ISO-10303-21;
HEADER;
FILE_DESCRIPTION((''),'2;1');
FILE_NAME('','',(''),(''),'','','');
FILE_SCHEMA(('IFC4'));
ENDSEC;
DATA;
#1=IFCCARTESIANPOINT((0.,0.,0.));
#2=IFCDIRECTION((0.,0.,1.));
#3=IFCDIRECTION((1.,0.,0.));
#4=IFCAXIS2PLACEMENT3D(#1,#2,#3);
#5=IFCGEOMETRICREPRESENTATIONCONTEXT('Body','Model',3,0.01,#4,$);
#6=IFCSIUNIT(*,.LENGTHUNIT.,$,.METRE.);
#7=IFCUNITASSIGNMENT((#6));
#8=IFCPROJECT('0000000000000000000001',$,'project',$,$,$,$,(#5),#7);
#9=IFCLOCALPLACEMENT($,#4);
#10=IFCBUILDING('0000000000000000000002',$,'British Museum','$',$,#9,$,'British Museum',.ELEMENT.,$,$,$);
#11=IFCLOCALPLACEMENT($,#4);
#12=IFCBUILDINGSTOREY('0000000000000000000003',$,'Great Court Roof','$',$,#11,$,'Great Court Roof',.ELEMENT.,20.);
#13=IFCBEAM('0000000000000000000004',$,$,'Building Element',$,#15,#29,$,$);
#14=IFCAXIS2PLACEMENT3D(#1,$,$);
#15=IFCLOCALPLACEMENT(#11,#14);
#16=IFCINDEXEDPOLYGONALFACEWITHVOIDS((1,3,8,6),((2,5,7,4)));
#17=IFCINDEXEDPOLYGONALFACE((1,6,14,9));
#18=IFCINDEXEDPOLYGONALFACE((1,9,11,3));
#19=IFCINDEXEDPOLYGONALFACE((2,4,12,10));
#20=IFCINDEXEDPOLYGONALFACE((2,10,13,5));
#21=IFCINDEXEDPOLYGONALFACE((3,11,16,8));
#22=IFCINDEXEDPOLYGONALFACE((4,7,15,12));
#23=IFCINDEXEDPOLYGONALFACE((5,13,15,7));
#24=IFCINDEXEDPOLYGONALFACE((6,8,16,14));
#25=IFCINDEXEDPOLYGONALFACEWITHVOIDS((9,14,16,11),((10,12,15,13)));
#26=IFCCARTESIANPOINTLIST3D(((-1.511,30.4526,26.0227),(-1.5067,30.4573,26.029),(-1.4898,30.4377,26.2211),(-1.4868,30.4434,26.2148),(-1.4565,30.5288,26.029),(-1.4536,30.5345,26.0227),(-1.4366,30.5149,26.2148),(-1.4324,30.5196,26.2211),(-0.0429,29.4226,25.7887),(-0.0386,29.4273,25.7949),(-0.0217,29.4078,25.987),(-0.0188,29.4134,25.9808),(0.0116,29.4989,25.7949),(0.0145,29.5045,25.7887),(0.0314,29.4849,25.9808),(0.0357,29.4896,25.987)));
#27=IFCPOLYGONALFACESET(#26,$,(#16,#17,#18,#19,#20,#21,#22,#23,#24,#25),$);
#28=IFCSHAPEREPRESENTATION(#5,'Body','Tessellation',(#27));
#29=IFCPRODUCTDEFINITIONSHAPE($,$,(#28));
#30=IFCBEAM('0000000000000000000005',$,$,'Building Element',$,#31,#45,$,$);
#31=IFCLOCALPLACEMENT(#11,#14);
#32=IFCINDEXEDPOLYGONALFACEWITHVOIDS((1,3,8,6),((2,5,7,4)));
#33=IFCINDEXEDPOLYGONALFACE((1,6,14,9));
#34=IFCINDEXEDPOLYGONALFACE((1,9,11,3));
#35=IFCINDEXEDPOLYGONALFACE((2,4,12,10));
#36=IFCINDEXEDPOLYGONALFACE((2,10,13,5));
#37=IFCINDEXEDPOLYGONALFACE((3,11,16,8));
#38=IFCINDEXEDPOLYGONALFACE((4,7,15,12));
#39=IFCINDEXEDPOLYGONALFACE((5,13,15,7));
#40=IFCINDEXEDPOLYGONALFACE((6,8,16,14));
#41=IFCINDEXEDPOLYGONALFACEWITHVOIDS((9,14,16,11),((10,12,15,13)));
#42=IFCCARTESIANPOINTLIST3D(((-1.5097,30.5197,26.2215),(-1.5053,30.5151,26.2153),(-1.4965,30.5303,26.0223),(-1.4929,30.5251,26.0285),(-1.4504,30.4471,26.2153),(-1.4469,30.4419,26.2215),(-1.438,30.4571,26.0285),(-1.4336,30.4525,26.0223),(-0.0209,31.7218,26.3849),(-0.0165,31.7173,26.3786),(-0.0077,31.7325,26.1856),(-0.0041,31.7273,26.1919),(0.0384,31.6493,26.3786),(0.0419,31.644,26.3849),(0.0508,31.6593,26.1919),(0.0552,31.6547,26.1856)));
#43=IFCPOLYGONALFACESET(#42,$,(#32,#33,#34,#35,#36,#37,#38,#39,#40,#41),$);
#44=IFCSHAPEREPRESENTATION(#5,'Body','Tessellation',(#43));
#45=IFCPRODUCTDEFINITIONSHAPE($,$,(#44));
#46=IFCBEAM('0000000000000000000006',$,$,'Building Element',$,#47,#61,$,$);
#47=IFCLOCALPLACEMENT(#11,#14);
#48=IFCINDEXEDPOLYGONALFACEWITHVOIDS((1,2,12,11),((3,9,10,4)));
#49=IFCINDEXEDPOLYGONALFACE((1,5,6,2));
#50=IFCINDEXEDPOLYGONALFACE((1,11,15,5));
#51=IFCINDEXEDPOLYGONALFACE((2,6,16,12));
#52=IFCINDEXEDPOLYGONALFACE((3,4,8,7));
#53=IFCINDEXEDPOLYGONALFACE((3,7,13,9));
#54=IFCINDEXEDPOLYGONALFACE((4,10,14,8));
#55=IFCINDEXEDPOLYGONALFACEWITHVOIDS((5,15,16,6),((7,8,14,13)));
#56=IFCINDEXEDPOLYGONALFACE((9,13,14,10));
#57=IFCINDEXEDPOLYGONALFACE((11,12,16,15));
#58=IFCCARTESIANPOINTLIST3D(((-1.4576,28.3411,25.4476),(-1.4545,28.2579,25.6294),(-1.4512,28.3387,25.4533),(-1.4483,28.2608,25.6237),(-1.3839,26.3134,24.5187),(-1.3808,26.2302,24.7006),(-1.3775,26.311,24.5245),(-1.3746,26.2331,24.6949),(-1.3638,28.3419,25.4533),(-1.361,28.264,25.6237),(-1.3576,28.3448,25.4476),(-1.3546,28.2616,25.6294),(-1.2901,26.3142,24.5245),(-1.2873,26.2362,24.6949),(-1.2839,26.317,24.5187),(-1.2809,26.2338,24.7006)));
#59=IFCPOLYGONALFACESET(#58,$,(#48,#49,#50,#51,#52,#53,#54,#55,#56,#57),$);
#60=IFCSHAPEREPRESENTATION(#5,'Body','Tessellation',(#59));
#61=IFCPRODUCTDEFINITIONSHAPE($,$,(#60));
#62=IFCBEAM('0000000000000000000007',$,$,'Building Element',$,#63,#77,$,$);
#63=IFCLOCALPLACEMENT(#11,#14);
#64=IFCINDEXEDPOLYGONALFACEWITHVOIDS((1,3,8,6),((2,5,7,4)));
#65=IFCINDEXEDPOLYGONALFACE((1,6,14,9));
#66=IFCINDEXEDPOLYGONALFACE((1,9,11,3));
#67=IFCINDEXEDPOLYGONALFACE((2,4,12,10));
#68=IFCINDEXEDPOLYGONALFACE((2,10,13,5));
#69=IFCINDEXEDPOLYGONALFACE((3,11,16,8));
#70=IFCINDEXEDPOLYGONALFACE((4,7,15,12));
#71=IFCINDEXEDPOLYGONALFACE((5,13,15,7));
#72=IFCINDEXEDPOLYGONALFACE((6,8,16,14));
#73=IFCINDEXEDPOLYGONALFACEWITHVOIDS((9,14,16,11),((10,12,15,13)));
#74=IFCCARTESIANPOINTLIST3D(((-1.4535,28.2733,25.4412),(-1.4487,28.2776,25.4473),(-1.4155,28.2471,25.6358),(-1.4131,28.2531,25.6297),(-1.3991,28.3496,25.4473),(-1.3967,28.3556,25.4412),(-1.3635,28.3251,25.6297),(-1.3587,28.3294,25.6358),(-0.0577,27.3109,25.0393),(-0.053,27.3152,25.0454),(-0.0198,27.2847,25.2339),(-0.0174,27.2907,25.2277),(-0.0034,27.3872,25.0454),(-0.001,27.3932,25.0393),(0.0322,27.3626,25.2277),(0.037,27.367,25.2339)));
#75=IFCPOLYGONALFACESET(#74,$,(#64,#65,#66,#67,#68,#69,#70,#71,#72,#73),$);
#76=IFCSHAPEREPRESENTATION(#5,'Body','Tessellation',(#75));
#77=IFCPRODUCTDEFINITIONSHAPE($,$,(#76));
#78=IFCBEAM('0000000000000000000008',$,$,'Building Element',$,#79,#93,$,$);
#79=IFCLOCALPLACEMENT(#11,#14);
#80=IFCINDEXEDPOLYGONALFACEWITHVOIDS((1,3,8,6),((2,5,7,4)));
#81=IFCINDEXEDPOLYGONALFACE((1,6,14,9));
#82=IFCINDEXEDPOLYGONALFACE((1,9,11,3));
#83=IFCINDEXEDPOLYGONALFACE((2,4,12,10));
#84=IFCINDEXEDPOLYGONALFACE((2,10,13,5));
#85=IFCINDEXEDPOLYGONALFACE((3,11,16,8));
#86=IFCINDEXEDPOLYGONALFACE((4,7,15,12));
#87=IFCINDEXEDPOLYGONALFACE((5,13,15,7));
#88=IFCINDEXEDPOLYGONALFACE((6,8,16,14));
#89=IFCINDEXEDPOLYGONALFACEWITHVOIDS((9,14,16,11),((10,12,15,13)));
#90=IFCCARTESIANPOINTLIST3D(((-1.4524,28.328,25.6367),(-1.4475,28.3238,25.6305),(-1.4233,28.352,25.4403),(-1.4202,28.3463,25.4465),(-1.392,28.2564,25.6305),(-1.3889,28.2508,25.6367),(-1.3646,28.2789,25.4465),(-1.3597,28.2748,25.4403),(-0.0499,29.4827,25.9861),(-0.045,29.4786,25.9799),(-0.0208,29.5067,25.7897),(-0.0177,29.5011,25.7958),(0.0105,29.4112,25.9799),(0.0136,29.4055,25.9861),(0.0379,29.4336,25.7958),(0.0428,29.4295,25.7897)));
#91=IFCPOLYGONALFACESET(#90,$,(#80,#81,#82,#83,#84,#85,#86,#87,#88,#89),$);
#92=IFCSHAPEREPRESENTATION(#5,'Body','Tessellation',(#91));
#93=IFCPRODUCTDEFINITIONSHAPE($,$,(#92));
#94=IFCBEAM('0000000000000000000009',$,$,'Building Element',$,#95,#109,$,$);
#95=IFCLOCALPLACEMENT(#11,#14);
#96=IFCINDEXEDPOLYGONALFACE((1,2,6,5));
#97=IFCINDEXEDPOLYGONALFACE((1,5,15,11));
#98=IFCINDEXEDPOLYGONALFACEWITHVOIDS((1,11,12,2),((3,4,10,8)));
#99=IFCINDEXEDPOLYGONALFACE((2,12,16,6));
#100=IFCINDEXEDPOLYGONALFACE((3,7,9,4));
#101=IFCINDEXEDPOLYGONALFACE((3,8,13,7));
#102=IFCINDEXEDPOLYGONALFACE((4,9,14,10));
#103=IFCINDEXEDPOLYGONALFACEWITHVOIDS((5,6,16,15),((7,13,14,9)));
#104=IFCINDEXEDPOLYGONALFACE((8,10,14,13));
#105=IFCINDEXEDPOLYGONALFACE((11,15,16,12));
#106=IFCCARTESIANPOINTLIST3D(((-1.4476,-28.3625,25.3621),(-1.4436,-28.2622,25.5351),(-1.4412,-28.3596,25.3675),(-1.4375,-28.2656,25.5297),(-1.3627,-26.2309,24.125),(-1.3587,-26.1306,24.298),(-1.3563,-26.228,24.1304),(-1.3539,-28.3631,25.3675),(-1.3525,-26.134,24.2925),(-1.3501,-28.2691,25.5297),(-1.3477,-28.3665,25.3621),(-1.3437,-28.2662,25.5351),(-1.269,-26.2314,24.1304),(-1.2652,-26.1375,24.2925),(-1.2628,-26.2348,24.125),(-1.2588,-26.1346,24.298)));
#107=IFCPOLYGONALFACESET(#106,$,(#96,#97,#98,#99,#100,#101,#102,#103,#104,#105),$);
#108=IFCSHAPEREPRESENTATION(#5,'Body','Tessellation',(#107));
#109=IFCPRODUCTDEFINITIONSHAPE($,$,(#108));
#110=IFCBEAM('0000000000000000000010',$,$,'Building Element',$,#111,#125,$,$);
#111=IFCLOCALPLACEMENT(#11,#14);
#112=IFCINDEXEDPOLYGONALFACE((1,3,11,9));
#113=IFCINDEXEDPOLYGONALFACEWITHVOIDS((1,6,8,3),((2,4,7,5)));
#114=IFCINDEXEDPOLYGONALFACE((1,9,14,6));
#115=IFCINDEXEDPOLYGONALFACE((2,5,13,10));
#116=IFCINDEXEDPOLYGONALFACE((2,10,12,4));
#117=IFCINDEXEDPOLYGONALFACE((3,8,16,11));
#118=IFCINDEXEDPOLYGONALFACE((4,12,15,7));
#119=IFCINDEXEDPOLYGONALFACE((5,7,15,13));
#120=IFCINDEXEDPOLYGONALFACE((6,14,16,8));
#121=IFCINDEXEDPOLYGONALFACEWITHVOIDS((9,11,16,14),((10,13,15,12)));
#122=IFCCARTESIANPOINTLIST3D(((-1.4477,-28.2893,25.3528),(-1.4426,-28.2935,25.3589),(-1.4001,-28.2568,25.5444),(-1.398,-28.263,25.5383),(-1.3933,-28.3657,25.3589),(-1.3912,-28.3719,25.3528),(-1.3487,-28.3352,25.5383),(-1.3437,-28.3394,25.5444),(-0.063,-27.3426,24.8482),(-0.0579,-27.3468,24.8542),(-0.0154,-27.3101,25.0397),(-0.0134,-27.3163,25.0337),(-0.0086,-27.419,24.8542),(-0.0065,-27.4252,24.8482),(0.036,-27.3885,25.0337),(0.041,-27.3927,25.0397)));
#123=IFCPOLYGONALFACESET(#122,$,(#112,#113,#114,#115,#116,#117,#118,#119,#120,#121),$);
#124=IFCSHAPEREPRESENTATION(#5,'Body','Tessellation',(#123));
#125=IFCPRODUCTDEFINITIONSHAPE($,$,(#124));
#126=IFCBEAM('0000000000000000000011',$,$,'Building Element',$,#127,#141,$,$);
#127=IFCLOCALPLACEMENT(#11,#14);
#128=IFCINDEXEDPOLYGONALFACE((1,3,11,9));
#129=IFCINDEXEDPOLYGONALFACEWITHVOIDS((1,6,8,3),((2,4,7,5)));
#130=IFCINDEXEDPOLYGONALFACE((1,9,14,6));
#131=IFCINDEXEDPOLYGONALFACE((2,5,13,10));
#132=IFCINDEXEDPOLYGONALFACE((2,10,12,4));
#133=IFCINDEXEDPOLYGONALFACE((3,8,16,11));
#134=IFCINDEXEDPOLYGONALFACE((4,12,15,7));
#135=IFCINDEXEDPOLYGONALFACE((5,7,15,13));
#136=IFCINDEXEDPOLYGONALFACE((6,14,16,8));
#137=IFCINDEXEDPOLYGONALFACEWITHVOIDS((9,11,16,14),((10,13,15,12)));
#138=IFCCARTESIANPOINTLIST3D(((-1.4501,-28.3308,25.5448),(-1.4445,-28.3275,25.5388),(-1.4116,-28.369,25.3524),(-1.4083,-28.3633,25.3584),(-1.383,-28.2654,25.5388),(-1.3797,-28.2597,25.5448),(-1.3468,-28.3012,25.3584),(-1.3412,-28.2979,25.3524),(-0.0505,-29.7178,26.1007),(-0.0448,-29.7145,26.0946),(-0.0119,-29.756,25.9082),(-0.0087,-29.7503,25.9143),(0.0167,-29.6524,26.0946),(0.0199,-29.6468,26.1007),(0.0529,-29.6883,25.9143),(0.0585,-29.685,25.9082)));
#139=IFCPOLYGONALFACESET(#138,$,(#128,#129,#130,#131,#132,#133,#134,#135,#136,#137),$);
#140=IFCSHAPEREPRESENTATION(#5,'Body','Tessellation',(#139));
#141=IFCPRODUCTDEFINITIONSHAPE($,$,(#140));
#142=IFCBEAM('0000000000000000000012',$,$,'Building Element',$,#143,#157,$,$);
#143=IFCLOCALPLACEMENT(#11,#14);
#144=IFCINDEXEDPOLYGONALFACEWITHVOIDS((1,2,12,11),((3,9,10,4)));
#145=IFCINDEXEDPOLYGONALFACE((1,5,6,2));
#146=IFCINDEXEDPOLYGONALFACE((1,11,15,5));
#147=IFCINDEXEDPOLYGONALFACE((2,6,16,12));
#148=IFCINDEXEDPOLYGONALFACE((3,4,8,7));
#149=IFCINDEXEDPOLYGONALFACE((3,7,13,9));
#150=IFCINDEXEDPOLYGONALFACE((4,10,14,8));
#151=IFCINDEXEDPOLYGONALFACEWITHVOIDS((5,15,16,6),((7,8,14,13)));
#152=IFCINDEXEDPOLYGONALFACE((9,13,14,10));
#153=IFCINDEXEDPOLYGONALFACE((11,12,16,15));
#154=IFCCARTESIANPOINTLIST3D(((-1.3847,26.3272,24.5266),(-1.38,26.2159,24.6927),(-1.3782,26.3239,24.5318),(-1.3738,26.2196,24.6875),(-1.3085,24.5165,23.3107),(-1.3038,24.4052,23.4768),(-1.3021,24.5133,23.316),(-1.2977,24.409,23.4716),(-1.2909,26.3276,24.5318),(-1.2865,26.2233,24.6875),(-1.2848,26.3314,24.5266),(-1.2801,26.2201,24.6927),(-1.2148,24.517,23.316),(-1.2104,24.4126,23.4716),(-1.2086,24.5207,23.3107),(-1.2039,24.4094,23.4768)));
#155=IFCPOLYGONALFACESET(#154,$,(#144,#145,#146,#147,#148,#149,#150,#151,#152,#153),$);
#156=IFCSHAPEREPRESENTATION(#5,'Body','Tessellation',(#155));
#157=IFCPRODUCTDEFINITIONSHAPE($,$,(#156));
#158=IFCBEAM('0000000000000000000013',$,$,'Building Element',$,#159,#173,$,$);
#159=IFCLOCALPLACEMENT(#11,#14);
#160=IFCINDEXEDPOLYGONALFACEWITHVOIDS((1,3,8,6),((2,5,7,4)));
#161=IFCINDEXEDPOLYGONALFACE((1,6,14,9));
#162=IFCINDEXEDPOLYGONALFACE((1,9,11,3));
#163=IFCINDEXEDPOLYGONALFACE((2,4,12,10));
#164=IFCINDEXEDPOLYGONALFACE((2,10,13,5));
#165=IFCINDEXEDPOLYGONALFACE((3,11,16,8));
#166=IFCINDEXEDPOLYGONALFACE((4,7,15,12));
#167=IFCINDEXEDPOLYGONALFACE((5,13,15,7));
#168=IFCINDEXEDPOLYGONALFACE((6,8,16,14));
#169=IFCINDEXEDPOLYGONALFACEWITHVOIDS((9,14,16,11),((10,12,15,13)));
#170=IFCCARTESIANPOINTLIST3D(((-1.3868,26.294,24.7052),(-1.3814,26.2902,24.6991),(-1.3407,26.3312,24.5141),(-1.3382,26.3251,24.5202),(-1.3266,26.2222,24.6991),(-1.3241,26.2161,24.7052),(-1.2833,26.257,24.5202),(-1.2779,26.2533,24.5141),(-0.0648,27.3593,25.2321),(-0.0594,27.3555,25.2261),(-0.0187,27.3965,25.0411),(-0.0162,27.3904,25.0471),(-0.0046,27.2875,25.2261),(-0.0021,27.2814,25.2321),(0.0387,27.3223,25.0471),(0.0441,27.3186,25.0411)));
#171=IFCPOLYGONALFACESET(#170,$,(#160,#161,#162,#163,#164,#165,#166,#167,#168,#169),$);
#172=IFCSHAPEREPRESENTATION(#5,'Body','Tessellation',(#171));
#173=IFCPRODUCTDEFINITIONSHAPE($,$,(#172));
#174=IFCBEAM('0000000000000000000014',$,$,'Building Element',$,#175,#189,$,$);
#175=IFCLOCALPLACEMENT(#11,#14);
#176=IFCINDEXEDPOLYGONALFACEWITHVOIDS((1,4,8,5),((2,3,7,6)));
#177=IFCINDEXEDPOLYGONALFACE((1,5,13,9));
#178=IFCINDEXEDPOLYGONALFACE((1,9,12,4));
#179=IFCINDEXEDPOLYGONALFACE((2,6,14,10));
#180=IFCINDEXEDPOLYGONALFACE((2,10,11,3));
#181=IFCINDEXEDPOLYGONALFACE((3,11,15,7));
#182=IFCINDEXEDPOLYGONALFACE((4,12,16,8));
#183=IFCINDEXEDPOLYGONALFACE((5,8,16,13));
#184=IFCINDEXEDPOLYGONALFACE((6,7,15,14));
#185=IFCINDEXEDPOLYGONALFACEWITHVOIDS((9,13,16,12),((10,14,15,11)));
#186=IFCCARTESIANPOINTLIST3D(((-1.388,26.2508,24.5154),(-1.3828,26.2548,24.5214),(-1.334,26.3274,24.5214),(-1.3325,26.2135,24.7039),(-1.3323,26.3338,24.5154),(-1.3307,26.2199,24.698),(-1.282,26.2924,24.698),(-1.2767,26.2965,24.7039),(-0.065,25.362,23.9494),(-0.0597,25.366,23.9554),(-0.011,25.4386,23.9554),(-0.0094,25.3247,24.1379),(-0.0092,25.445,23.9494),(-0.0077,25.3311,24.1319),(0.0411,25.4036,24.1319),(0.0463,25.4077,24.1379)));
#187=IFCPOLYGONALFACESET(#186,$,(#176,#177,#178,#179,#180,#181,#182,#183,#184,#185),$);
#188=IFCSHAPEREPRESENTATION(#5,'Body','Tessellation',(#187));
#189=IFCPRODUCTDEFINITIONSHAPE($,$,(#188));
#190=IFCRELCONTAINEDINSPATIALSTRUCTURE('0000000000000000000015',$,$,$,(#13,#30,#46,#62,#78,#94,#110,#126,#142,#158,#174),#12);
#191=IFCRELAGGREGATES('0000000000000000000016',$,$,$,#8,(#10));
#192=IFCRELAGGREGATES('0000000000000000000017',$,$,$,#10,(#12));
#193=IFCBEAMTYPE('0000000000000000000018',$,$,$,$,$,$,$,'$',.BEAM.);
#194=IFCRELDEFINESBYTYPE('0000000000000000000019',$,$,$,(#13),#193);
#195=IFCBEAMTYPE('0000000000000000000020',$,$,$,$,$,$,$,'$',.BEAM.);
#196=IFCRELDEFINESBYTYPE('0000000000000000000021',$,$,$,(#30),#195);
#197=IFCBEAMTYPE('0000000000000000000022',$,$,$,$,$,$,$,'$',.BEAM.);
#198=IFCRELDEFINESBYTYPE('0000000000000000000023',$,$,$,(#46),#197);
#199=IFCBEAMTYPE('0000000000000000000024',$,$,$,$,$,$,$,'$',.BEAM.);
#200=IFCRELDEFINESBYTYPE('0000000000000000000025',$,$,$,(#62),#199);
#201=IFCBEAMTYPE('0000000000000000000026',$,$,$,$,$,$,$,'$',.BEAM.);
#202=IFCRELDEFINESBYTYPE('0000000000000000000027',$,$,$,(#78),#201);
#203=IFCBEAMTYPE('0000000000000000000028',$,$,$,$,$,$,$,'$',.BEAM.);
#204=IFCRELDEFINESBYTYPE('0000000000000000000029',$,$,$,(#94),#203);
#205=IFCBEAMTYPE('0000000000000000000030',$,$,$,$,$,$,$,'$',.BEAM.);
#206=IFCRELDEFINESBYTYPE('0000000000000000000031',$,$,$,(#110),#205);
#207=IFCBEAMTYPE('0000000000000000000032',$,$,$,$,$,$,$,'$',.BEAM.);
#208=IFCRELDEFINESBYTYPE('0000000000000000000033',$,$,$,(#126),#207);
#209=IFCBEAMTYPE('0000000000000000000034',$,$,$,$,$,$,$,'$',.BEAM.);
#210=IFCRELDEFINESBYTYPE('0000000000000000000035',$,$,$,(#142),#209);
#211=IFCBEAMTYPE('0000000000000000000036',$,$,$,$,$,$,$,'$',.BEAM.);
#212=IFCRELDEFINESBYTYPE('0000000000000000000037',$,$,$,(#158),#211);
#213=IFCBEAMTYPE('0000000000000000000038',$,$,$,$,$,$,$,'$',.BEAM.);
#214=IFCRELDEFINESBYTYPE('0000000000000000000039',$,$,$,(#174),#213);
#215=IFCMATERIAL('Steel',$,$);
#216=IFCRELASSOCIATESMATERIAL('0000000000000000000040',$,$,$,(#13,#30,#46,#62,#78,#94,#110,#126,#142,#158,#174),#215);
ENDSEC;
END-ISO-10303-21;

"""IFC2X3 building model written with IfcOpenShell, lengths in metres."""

from ifc_helpers import new_model, si_unit, frame, origin_with_axes, origin_2d, place, context, project, spatial, hollow_rectangle, extrude, material, type_object, element, save


model = new_model("IFC2X3")

# Units and contexts
model_context = context("Model", 3, precision=0.01, world=origin_with_axes(), identifier="Body")
ifc_project = project(units=[si_unit("LENGTHUNIT", "METRE")], contexts=[model_context])

# Building, storey
building_placement = place(None, origin_with_axes())
building = spatial("IfcBuilding", under=ifc_project, at=building_placement, Name="British Museum", Description="$", LongName="British Museum", CompositionType="ELEMENT")
storey_placement = place(None, origin_with_axes())
storey = spatial("IfcBuildingStorey", under=building, at=storey_placement, Name="Great Court Roof", Description="$", LongName="Great Court Roof", CompositionType="ELEMENT", Elevation=20.0)

# Beams
ifc_material = material(Name="Steel")
beam_type_1 = type_object("IfcBeamType", ElementType="$", PredefinedType="BEAM")
beam_1_placement = place(None, origin_with_axes())
element("IfcBeam", 1, at=beam_1_placement, inside=storey, type_object=beam_type_1, material=ifc_material, Description="Building Element", context=model_context, shape_type="SweptSolid", body=[
    extrude(hollow_rectangle(XDim=0.1, YDim=0.2, WallThickness=0.0063, InnerFilletRadius=-0.0063, OuterFilletRadius=0.0, at=origin_2d()), frame((-1.4717, 30.4861, 26.1219), z_axis=(0.811744, -0.569495, -0.12941), x_axis=(0.574324, 0.818628, 0.0)), (0.0, 0.0, 1.0), 1.8086),
])
beam_type_2 = type_object("IfcBeamType", ElementType="$", PredefinedType="BEAM")
beam_2_placement = place(None, origin_with_axes())
element("IfcBeam", 2, at=beam_2_placement, inside=storey, type_object=beam_type_2, material=ifc_material, Description="Building Element", context=model_context, shape_type="SweptSolid", body=[
    extrude(hollow_rectangle(XDim=0.1, YDim=0.2, WallThickness=0.0063, InnerFilletRadius=-0.0063, OuterFilletRadius=0.0, at=origin_2d()), frame((-1.4717, 30.4861, 26.1219), z_axis=(0.775204, 0.625961, 0.085035), x_axis=(-0.628237, 0.778022, 0.0)), (0.0, 0.0, 1.0), 1.9205),
])
beam_type_3 = type_object("IfcBeamType", ElementType="$", PredefinedType="BEAM")
beam_3_placement = place(None, origin_with_axes())
element("IfcBeam", 3, at=beam_3_placement, inside=storey, type_object=beam_type_3, material=ifc_material, Description="Building Element", context=model_context, shape_type="SweptSolid", body=[
    extrude(hollow_rectangle(XDim=0.1, YDim=0.2, WallThickness=0.0063, InnerFilletRadius=-0.0063, OuterFilletRadius=0.0, at=origin_2d()), frame((-1.4061, 28.3014, 25.5385), z_axis=(0.033031, -0.908655, -0.416238), x_axis=(0.99934, 0.036328, 0.0)), (0.0, 0.0, 1.0), 2.2316),
])
beam_type_4 = type_object("IfcBeamType", ElementType="$", PredefinedType="BEAM")
beam_4_placement = place(None, origin_with_axes())
element("IfcBeam", 4, at=beam_4_placement, inside=storey, type_object=beam_type_4, material=ifc_material, Description="Building Element", context=model_context, shape_type="SweptSolid", body=[
    extrude(hollow_rectangle(XDim=0.1, YDim=0.2, WallThickness=0.0063, InnerFilletRadius=-0.0063, OuterFilletRadius=0.0, at=origin_2d()), frame((-1.4061, 28.3014, 25.5385), z_axis=(0.801042, -0.55237, -0.230692), x_axis=(0.567682, 0.823248, 0.0)), (0.0, 0.0, 1.0), 1.7424),
])
beam_type_5 = type_object("IfcBeamType", ElementType="$", PredefinedType="BEAM")
beam_5_placement = place(None, origin_with_axes())
element("IfcBeam", 5, at=beam_5_placement, inside=storey, type_object=beam_type_5, material=ifc_material, Description="Building Element", context=model_context, shape_type="SweptSolid", body=[
    extrude(hollow_rectangle(XDim=0.1, YDim=0.2, WallThickness=0.0063, InnerFilletRadius=-0.0063, OuterFilletRadius=0.0, at=origin_2d()), frame((-1.4061, 28.3014, 25.5385), z_axis=(0.758101, 0.624199, 0.188832), x_axis=(-0.635635, 0.77199, 0.0)), (0.0, 0.0, 1.0), 1.85),
])
beam_type_6 = type_object("IfcBeamType", ElementType="$", PredefinedType="BEAM")
beam_6_placement = place(None, origin_with_axes())
element("IfcBeam", 6, at=beam_6_placement, inside=storey, type_object=beam_type_6, material=ifc_material, Description="Building Element", context=model_context, shape_type="SweptSolid", body=[
    extrude(hollow_rectangle(XDim=0.1, YDim=0.2, WallThickness=0.0063, InnerFilletRadius=-0.0063, OuterFilletRadius=0.0, at=origin_2d()), frame((-1.3957, -28.3144, 25.4486), z_axis=(0.034428, 0.864382, -0.501656), x_axis=(-0.999208, 0.039798, 0.0)), (0.0, 0.0, 1.0), 2.4661),
])
beam_type_7 = type_object("IfcBeamType", ElementType="$", PredefinedType="BEAM")
beam_7_placement = place(None, origin_with_axes())
element("IfcBeam", 7, at=beam_7_placement, inside=storey, type_object=beam_type_7, material=ifc_material, Description="Building Element", context=model_context, shape_type="SweptSolid", body=[
    extrude(hollow_rectangle(XDim=0.1, YDim=0.2, WallThickness=0.0063, InnerFilletRadius=-0.0063, OuterFilletRadius=0.0, at=origin_2d()), frame((-1.3957, -28.3144, 25.4486), z_axis=(0.790499, 0.540472, -0.288099), x_axis=(-0.564403, 0.8255, 0.0)), (0.0, 0.0, 1.0), 1.7516),
])
beam_type_8 = type_object("IfcBeamType", ElementType="$", PredefinedType="BEAM")
beam_8_placement = place(None, origin_with_axes())
element("IfcBeam", 8, at=beam_8_placement, inside=storey, type_object=beam_type_8, material=ifc_material, Description="Building Element", context=model_context, shape_type="SweptSolid", body=[
    extrude(hollow_rectangle(XDim=0.1, YDim=0.2, WallThickness=0.0063, InnerFilletRadius=-0.0063, OuterFilletRadius=0.0, at=origin_2d()), frame((-1.3957, -28.3144, 25.4486), z_axis=(0.683632, -0.677454, 0.271485), x_axis=(0.70389, 0.710309, 0.0)), (0.0, 0.0, 1.0), 2.0474),
])
beam_type_9 = type_object("IfcBeamType", ElementType="$", PredefinedType="BEAM")
beam_9_placement = place(None, origin_with_axes())
element("IfcBeam", 9, at=beam_9_placement, inside=storey, type_object=beam_type_9, material=ifc_material, Description="Building Element", context=model_context, shape_type="SweptSolid", body=[
    extrude(hollow_rectangle(XDim=0.1, YDim=0.2, WallThickness=0.0063, InnerFilletRadius=-0.0063, OuterFilletRadius=0.0, at=origin_2d()), frame((-1.3324, 26.2736, 24.6097), z_axis=(0.034893, -0.829685, -0.55714), x_axis=(0.999117, 0.042018, 0.0)), (0.0, 0.0, 1.0), 2.1823),
])
beam_type_10 = type_object("IfcBeamType", ElementType="$", PredefinedType="BEAM")
beam_10_placement = place(None, origin_with_axes())
element("IfcBeam", 10, at=beam_10_placement, inside=storey, type_object=beam_type_10, material=ifc_material, Description="Building Element", context=model_context, shape_type="SweptSolid", body=[
    extrude(hollow_rectangle(XDim=0.1, YDim=0.2, WallThickness=0.0063, InnerFilletRadius=-0.0063, OuterFilletRadius=0.0, at=origin_2d()), frame((-1.3324, 26.2736, 24.6097), z_axis=(0.743664, 0.599257, 0.296403), x_axis=(-0.627453, 0.778654, 0.0)), (0.0, 0.0, 1.0), 1.7777),
])
beam_type_11 = type_object("IfcBeamType", ElementType="$", PredefinedType="BEAM")
beam_11_placement = place(None, origin_with_axes())
element("IfcBeam", 11, at=beam_11_placement, inside=storey, type_object=beam_type_11, material=ifc_material, Description="Building Element", context=model_context, shape_type="SweptSolid", body=[
    extrude(hollow_rectangle(XDim=0.1, YDim=0.2, WallThickness=0.0063, InnerFilletRadius=-0.0063, OuterFilletRadius=0.0, at=origin_2d()), frame((-1.3324, 26.2736, 24.6097), z_axis=(0.782226, -0.525487, -0.334643), x_axis=(0.557638, 0.830084, 0.0)), (0.0, 0.0, 1.0), 1.6914),
])

save(model, "model.ifc")
